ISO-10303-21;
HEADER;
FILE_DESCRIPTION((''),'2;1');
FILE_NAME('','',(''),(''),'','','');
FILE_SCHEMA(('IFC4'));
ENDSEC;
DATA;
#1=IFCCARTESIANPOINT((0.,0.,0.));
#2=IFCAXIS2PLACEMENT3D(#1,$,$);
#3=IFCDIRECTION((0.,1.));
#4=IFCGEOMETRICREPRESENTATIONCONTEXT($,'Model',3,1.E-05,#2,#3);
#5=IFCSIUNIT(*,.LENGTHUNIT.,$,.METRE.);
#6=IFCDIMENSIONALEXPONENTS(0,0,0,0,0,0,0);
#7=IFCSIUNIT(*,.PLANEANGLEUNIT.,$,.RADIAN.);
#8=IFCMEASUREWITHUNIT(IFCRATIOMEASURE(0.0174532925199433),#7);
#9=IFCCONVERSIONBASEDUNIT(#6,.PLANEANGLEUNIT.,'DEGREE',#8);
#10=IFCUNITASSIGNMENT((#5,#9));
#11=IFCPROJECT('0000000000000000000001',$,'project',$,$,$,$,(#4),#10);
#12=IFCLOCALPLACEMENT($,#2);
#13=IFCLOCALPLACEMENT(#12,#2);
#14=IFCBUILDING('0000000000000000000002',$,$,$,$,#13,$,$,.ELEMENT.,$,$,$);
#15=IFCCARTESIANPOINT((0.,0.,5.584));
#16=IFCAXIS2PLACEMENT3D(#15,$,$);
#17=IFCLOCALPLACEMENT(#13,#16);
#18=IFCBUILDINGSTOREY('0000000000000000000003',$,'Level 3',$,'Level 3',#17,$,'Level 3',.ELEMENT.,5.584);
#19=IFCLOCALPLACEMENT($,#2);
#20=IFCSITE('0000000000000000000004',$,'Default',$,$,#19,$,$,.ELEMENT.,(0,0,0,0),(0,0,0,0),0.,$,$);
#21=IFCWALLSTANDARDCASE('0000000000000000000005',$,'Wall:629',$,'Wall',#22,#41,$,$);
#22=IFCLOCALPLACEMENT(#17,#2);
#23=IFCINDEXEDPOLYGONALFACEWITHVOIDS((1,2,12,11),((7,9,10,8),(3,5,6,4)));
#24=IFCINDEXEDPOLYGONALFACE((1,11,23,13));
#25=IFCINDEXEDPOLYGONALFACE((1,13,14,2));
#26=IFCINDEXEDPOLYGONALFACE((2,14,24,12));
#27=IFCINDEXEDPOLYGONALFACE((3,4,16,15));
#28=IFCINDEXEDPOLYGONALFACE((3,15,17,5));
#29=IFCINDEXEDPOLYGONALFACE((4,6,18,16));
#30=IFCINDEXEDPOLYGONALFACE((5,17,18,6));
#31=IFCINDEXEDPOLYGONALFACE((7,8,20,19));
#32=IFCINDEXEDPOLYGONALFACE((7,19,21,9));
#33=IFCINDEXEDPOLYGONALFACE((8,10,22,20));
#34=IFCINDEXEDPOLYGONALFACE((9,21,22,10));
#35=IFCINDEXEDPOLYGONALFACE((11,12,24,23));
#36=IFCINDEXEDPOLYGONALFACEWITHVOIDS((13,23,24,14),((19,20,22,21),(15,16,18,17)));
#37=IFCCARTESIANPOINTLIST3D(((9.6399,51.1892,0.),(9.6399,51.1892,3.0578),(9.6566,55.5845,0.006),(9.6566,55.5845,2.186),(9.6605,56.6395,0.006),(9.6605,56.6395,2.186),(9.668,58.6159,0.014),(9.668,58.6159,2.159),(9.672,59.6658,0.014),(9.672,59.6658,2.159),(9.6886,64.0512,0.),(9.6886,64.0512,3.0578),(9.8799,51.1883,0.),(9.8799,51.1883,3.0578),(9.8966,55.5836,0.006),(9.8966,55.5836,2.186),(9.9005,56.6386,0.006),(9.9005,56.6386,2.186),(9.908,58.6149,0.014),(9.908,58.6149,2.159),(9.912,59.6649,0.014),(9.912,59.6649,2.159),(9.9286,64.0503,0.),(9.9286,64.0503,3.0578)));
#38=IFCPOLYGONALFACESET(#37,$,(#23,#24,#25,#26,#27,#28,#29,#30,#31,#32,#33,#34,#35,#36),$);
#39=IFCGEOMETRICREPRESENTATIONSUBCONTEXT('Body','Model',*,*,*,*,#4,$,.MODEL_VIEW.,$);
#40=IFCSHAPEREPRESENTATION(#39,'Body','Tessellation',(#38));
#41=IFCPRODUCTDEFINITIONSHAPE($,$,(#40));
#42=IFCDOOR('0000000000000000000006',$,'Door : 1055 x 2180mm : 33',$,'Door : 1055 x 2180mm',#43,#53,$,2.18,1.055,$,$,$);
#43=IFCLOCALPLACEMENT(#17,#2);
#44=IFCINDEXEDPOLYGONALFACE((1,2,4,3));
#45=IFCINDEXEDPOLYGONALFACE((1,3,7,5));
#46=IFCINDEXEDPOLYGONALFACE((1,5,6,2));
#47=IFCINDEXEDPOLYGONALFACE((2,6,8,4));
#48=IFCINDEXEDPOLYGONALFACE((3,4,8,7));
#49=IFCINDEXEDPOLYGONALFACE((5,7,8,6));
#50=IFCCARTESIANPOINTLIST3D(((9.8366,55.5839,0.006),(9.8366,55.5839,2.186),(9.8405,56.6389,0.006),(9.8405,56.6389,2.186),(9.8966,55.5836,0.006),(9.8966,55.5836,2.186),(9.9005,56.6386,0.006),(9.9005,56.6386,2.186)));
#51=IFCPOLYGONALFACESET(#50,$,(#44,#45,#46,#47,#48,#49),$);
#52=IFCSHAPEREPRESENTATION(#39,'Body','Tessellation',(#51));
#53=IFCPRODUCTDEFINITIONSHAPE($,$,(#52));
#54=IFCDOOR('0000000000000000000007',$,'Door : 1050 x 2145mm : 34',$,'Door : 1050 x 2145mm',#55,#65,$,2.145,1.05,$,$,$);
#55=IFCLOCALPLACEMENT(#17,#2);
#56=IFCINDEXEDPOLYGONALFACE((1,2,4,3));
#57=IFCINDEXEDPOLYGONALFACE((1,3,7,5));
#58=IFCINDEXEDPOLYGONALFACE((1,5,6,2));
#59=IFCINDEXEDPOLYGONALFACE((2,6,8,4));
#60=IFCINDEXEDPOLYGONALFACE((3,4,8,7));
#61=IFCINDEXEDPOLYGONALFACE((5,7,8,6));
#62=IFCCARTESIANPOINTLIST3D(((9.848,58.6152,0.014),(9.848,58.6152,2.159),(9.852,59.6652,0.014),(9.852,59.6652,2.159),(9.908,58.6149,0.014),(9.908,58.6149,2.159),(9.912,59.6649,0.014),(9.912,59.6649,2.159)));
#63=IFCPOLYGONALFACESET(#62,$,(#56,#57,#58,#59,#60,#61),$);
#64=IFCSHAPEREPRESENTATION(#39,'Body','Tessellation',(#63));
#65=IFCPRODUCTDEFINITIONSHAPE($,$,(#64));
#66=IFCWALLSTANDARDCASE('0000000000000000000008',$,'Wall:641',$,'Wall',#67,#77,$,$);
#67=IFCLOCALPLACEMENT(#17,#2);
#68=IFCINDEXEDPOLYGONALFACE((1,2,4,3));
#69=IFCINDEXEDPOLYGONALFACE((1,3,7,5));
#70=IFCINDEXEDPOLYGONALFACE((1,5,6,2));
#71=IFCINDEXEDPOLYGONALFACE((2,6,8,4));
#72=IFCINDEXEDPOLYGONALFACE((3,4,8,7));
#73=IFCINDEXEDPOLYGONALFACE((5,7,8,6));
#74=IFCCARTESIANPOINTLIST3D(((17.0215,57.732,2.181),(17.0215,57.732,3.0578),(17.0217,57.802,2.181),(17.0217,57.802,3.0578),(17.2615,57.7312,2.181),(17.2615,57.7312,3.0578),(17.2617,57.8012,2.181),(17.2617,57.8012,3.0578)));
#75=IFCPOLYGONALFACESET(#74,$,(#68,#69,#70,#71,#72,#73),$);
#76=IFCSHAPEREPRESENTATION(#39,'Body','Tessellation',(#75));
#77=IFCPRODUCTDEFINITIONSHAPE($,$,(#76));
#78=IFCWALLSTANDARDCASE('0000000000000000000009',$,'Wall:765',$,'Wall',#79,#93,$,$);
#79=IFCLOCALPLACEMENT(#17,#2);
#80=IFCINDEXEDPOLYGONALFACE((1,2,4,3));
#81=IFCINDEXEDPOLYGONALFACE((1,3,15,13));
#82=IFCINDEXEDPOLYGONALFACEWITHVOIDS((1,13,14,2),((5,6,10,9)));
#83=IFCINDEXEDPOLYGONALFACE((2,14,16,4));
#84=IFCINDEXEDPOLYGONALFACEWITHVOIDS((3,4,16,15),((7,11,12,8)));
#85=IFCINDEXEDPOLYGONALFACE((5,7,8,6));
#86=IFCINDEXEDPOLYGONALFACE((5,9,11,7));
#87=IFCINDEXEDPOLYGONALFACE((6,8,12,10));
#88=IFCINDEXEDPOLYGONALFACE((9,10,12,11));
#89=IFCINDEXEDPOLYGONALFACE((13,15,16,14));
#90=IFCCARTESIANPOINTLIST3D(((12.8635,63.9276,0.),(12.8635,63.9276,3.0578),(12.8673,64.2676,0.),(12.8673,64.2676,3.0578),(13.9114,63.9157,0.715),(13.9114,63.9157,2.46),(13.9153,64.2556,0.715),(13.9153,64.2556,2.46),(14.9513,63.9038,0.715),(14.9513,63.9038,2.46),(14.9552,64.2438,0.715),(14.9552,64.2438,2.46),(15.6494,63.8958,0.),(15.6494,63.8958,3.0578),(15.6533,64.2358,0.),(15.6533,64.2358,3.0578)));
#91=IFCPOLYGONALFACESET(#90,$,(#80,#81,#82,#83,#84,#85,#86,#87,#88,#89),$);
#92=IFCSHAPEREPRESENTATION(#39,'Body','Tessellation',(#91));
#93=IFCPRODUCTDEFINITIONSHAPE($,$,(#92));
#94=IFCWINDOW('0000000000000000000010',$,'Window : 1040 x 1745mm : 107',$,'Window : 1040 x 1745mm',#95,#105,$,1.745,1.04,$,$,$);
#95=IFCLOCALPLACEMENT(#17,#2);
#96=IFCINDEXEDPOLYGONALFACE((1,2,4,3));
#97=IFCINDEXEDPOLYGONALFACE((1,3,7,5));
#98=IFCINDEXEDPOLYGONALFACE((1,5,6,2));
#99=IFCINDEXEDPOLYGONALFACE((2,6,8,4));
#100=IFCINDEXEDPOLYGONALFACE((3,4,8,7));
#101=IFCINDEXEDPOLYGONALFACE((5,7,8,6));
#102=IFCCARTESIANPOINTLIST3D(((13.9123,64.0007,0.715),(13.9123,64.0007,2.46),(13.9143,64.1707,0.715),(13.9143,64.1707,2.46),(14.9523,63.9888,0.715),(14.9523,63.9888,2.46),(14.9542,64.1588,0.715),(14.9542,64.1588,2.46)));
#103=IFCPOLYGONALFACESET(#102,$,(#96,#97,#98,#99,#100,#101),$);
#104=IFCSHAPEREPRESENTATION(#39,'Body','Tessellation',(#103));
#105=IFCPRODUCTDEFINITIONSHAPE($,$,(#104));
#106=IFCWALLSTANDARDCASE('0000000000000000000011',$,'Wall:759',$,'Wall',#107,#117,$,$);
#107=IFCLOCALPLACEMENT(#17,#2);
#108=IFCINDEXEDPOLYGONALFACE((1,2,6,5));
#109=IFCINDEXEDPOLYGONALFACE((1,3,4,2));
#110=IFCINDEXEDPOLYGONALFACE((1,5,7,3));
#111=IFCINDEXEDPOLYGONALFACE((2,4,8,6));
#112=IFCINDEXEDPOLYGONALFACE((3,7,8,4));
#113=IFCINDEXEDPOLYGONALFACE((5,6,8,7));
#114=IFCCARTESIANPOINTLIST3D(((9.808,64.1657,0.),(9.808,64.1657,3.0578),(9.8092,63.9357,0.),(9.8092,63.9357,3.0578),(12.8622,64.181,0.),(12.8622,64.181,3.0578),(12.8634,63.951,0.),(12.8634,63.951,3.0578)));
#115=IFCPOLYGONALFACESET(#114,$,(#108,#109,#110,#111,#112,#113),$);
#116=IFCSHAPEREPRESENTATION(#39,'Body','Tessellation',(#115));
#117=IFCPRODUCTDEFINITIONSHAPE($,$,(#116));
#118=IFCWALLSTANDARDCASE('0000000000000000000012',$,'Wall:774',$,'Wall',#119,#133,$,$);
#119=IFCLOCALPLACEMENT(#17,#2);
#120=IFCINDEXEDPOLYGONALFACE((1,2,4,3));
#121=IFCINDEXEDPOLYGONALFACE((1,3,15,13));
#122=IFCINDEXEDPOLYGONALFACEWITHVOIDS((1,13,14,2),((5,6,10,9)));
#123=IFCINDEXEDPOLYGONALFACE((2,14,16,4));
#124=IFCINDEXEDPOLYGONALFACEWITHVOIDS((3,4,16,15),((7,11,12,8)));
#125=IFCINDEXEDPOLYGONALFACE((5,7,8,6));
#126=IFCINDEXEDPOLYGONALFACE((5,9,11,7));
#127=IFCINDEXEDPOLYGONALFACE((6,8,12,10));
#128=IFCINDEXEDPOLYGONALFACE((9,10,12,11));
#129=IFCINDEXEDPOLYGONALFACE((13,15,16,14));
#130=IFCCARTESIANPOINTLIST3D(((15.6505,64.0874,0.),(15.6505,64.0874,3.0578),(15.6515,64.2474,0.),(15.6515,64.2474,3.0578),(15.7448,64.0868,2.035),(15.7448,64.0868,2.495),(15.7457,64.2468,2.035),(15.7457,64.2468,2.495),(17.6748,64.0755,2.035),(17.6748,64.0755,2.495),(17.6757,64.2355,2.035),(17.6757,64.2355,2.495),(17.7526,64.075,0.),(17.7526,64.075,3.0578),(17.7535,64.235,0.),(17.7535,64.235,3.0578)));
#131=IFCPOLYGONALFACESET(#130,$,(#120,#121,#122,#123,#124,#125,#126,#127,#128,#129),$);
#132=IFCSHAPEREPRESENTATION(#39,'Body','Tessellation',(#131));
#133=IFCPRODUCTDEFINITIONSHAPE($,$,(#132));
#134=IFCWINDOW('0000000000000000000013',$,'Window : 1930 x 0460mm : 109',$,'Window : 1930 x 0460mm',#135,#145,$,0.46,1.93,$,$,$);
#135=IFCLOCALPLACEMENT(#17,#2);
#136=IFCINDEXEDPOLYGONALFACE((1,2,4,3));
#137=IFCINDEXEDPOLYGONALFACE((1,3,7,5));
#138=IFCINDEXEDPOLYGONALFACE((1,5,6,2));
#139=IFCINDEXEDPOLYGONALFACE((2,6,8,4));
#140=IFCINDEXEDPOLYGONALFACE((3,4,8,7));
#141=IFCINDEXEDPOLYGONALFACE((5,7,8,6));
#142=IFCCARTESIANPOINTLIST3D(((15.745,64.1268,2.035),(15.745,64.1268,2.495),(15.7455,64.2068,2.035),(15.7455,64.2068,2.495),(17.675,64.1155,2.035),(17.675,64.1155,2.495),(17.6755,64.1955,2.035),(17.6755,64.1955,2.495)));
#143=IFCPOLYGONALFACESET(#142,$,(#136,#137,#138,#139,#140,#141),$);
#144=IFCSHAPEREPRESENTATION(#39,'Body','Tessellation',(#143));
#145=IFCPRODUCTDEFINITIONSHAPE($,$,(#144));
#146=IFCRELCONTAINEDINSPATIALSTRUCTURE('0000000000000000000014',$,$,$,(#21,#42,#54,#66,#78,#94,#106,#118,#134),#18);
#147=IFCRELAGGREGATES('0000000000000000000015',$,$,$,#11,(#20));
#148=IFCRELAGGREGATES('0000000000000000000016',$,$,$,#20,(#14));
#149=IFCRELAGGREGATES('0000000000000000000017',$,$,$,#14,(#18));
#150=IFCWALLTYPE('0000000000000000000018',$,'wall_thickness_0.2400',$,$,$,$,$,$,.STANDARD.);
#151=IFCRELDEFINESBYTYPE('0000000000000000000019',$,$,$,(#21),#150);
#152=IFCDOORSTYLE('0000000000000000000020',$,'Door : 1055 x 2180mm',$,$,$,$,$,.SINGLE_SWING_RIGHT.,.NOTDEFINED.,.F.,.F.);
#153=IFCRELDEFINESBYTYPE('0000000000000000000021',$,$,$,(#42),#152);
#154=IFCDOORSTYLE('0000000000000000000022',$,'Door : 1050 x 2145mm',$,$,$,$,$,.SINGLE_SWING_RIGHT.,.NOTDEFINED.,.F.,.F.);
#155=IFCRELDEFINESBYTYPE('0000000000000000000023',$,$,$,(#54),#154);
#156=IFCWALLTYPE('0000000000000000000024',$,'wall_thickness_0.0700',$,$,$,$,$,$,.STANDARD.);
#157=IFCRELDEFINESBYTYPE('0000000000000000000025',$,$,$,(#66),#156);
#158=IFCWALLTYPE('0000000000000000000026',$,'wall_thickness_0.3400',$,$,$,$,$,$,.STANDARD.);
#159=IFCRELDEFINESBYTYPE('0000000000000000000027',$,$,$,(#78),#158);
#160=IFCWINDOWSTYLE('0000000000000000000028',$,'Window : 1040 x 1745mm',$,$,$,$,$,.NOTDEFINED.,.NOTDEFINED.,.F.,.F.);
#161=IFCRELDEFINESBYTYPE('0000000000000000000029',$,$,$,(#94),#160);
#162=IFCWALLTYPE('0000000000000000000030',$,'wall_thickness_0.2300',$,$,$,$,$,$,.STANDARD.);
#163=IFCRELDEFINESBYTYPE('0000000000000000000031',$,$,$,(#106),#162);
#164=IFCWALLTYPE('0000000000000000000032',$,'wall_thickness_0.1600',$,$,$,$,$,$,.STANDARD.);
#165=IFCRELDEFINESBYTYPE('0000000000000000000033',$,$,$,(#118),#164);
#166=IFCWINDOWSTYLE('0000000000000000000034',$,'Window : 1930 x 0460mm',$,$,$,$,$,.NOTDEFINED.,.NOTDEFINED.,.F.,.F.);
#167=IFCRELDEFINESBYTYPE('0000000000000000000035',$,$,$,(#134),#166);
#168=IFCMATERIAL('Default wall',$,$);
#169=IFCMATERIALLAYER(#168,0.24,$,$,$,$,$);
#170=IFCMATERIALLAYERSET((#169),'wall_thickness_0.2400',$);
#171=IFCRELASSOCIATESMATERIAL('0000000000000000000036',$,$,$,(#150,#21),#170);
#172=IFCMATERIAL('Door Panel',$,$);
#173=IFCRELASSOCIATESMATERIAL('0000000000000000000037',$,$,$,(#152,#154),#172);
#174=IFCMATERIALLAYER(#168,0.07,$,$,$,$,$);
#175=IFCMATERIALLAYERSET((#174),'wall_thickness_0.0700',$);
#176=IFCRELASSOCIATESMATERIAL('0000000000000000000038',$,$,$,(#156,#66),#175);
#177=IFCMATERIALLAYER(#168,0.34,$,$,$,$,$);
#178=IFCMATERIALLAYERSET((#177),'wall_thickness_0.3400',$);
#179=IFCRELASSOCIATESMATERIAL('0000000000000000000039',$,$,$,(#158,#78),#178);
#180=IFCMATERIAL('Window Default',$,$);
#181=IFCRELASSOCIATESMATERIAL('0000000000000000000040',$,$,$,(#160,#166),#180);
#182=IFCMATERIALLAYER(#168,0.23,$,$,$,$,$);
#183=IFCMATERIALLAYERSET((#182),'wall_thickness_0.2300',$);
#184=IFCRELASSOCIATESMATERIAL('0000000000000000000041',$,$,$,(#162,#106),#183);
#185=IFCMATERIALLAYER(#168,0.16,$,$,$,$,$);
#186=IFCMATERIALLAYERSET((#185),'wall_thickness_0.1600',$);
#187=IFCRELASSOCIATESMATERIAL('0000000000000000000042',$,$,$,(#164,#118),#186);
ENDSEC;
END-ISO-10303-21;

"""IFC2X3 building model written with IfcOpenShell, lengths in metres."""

from ifc_helpers import new_model, entity, si_unit, converted_unit, direction, frame, frame_2d, origin, origin_2d_with_axis, place, context, subcontext, project, spatial, polyline, rectangle, outline, extrude, source, transform, mapped, material, layer, layer_set, layer_usage, type_object, type_shapes, element, fill, save


model = new_model("IFC2X3")

# Units and contexts
model_context = context("Model", 3, precision=1e-05, world=origin(), true_north=direction((0.0, 1.0)))
body_context = subcontext(model_context, "Body", "Model", "MODEL_VIEW")
ifc_project = project(units=[si_unit("LENGTHUNIT", "METRE"), converted_unit("PLANEANGLEUNIT", "DEGREE", entity("IfcRatioMeasure", 0.0174532925199433), si_unit("PLANEANGLEUNIT", "RADIAN"), dimensions=[0, 0, 0, 0, 0, 0, 0])], contexts=[model_context])

# Site, building, storey
site_placement = place(None, origin())
site = spatial("IfcSite", under=ifc_project, at=site_placement, Name="Default", CompositionType="ELEMENT", RefLatitude=(0, 0, 0, 0), RefLongitude=(0, 0, 0, 0), RefElevation=0.0)
placement_1 = place(None, origin())
building_placement = place(placement_1, origin())
building = spatial("IfcBuilding", under=site, at=building_placement, CompositionType="ELEMENT")
storey_placement = place(building_placement, frame((0.0, 0.0, 5.584)))
storey = spatial("IfcBuildingStorey", under=building, at=storey_placement, Name="Level 3", ObjectType="Level 3", LongName="Level 3", CompositionType="ELEMENT", Elevation=5.584)

# Shared definitions
ifc_material_1 = material(Name="Default wall")

# Shared definitions
ifc_material_2 = material(Name="Window Default")

# Wall, openings, doors
ifc_layer_1 = layer(ifc_material_1, 0.24)
ifc_layer_set_1 = layer_set([ifc_layer_1], Name="wall_thickness_0.2400")
ifc_layer_usage_1 = layer_usage(ifc_layer_set_1, "AXIS2", "POSITIVE", -0.12)
wall_type_1 = type_object("IfcWallType", Name="wall_thickness_0.2400", PredefinedType="STANDARD", material=ifc_layer_set_1)
wall_1_placement = place(storey_placement, frame((9.8086, 64.0507, 0.0), z_axis=(0.0, 0.0, 1.0), x_axis=(-0.003783, -0.999993, 0.0)))
wall_1 = element("IfcWallStandardCase", 1, at=wall_1_placement, inside=storey, type_object=wall_type_1, material=ifc_layer_usage_1, Name="Wall:629", ObjectType="Wall", context=body_context, shape_type="SweptSolid", body=[
    extrude(outline(polyline([(12.8621, -0.12), (12.8621, 0.12), (0.0, 0.12), (0.0, -0.12), (12.8621, -0.12)])), origin(), (0.0, 0.0, 1.0), 3.0578),
])
opening_1_placement = place(wall_1_placement, frame((7.4117, -0.12, 0.006)))
opening_1 = element("IfcOpeningElement", 2, at=opening_1_placement, cuts=wall_1, ObjectType="Opening", context=body_context, shape_type="SweptSolid", body=[
    extrude(rectangle(XDim=1.055, YDim=2.18, at=frame_2d((1.09, 0.5275), x_axis=(0.0, 1.0))), frame((0.0, 0.0, 0.0), z_axis=(0.0, 1.0, 0.0), x_axis=(0.0, 0.0, 1.0)), (0.0, 0.0, 1.0), 0.24),
])
opening_2_placement = place(wall_1_placement, frame((4.3854, -0.12, 0.014)))
opening_2 = element("IfcOpeningElement", 3, at=opening_2_placement, cuts=wall_1, ObjectType="Opening", context=body_context, shape_type="SweptSolid", body=[
    extrude(rectangle(XDim=1.05, YDim=2.145, at=frame_2d((1.0725, 0.525), x_axis=(0.0, 1.0))), frame((0.0, 0.0, 0.0), z_axis=(0.0, 1.0, 0.0), x_axis=(0.0, 0.0, 1.0)), (0.0, 0.0, 1.0), 0.24),
])
ifc_material_3 = material(Name="Door Panel")
door_style_1 = type_object("IfcDoorStyle", Name="Door : 1055 x 2180mm", ConstructionType="NOTDEFINED", OperationType="SINGLE_SWING_RIGHT", ParameterTakesPrecedence=False, Sizeable=False, material=ifc_material_3)
shared_shape_1 = source(origin(), body_context, "Body", "SweptSolid", [
    extrude(rectangle(XDim=0.06, YDim=1.055, at=origin_2d_with_axis()), frame((0.5275, 0.21, 0.0), z_axis=(0.0, 0.0, 1.0), x_axis=(0.0, 1.0, 0.0)), (0.0, 0.0, 1.0), 2.18),
])
type_shapes(door_style_1, [shared_shape_1])
door_1_placement = place(opening_1_placement, origin())
door_1 = element("IfcDoor", 4, at=door_1_placement, inside=storey, type_object=door_style_1, Name="Door : 1055 x 2180mm : 33", ObjectType="Door : 1055 x 2180mm", OverallHeight=2.18, OverallWidth=1.055, context=body_context, shape_type="MappedRepresentation", body=[
    mapped(shared_shape_1, transform((0.0, 0.0, 0.0), scale=1.0)),
])
fill(opening_1, door_1)
door_style_2 = type_object("IfcDoorStyle", Name="Door : 1050 x 2145mm", ConstructionType="NOTDEFINED", OperationType="SINGLE_SWING_RIGHT", ParameterTakesPrecedence=False, Sizeable=False, material=ifc_material_3)
shared_shape_2 = source(origin(), body_context, "Body", "SweptSolid", [
    extrude(rectangle(XDim=0.06, YDim=1.05, at=origin_2d_with_axis()), frame((0.525, 0.21, 0.0), z_axis=(0.0, 0.0, 1.0), x_axis=(0.0, 1.0, 0.0)), (0.0, 0.0, 1.0), 2.145),
])
type_shapes(door_style_2, [shared_shape_2])
door_2_placement = place(opening_2_placement, origin())
door_2 = element("IfcDoor", 5, at=door_2_placement, inside=storey, type_object=door_style_2, Name="Door : 1050 x 2145mm : 34", ObjectType="Door : 1050 x 2145mm", OverallHeight=2.145, OverallWidth=1.05, context=body_context, shape_type="MappedRepresentation", body=[
    mapped(shared_shape_2, transform((0.0, 0.0, 0.0), scale=1.0)),
])
fill(opening_2, door_2)

# Wall
ifc_layer_2 = layer(ifc_material_1, 0.07)
ifc_layer_set_2 = layer_set([ifc_layer_2], Name="wall_thickness_0.0700")
ifc_layer_usage_2 = layer_usage(ifc_layer_set_2, "AXIS2", "POSITIVE", -0.035)
wall_type_2 = type_object("IfcWallType", Name="wall_thickness_0.0700", PredefinedType="STANDARD", material=ifc_layer_set_2)
placement_2 = place(building_placement, frame((0.0, 0.0, 7.765)))
wall_2_placement = place(placement_2, frame((17.0216, 57.767, 0.0), z_axis=(0.0, 0.0, 1.0), x_axis=(0.999995, -0.00302, 0.0)))
element("IfcWallStandardCase", 6, at=wall_2_placement, inside=storey, type_object=wall_type_2, material=ifc_layer_usage_2, Name="Wall:641", ObjectType="Wall", context=body_context, shape_type="SweptSolid", body=[
    extrude(outline(polyline([(0.24, -0.035), (0.24, 0.035), (0.0, 0.035), (0.0, -0.035), (0.24, -0.035)])), origin(), (0.0, 0.0, 1.0), 0.8768),
])

# Wall, opening, window
ifc_layer_3 = layer(ifc_material_1, 0.34)
ifc_layer_set_3 = layer_set([ifc_layer_3], Name="wall_thickness_0.3400")
ifc_layer_usage_3 = layer_usage(ifc_layer_set_3, "AXIS2", "POSITIVE", -0.17)
wall_type_3 = type_object("IfcWallType", Name="wall_thickness_0.3400", PredefinedType="STANDARD", material=ifc_layer_set_3)
wall_3_placement = place(storey_placement, frame((12.8654, 64.0976, 0.0), z_axis=(0.0, 0.0, 1.0), x_axis=(0.999935, -0.011416, 0.0)))
wall_3 = element("IfcWallStandardCase", 7, at=wall_3_placement, inside=storey, type_object=wall_type_3, material=ifc_layer_usage_3, Name="Wall:765", ObjectType="Wall", context=body_context, shape_type="SweptSolid", body=[
    extrude(outline(polyline([(2.7861, -0.17), (2.7861, 0.17), (0.0, 0.17), (0.0, -0.17), (2.7861, -0.17)])), origin(), (0.0, 0.0, 1.0), 3.0578),
])
opening_3_placement = place(wall_3_placement, frame((1.048, -0.17, 0.715)))
opening_3 = element("IfcOpeningElement", 8, at=opening_3_placement, cuts=wall_3, ObjectType="Opening", context=body_context, shape_type="SweptSolid", body=[
    extrude(rectangle(XDim=1.04, YDim=1.745, at=frame_2d((0.8725, 0.52), x_axis=(0.0, 1.0))), frame((0.0, 0.0, 0.0), z_axis=(0.0, 1.0, 0.0), x_axis=(0.0, 0.0, 1.0)), (0.0, 0.0, 1.0), 0.34),
])
window_style_1 = type_object("IfcWindowStyle", Name="Window : 1040 x 1745mm", ConstructionType="NOTDEFINED", OperationType="NOTDEFINED", ParameterTakesPrecedence=False, Sizeable=False, material=ifc_material_2)
shared_shape_3 = source(origin(), body_context, "Body", "SweptSolid", [
    extrude(rectangle(XDim=0.17, YDim=1.04, at=origin_2d_with_axis()), frame((0.52, 0.17, 0.0), z_axis=(0.0, 0.0, 1.0), x_axis=(0.0, 1.0, 0.0)), (0.0, 0.0, 1.0), 1.745),
])
type_shapes(window_style_1, [shared_shape_3])
window_1_placement = place(opening_3_placement, origin())
window_1 = element("IfcWindow", 9, at=window_1_placement, inside=storey, type_object=window_style_1, Name="Window : 1040 x 1745mm : 107", ObjectType="Window : 1040 x 1745mm", OverallHeight=1.745, OverallWidth=1.04, context=body_context, shape_type="MappedRepresentation", body=[
    mapped(shared_shape_3, transform((0.0, 0.0, 0.0), scale=1.0)),
])
fill(opening_3, window_1)

# Wall
ifc_layer_4 = layer(ifc_material_1, 0.23)
ifc_layer_set_4 = layer_set([ifc_layer_4], Name="wall_thickness_0.2300")
ifc_layer_usage_4 = layer_usage(ifc_layer_set_4, "AXIS2", "POSITIVE", -0.115)
wall_type_4 = type_object("IfcWallType", Name="wall_thickness_0.2300", PredefinedType="STANDARD", material=ifc_layer_set_4)
wall_4_placement = place(storey_placement, frame((9.8086, 64.0507, 0.0), z_axis=(0.0, 0.0, 1.0), x_axis=(0.999987, 0.005001, 0.0)))
element("IfcWallStandardCase", 10, at=wall_4_placement, inside=storey, type_object=wall_type_4, material=ifc_layer_usage_4, Name="Wall:759", ObjectType="Wall", context=body_context, shape_type="SweptSolid", body=[
    extrude(outline(polyline([(3.0542, -0.115), (3.0542, 0.115), (0.0, 0.115), (0.0, -0.115), (3.0542, -0.115)])), origin(), (0.0, 0.0, 1.0), 3.0578),
])

# Wall, opening, window
ifc_layer_5 = layer(ifc_material_1, 0.16)
ifc_layer_set_5 = layer_set([ifc_layer_5], Name="wall_thickness_0.1600")
ifc_layer_usage_5 = layer_usage(ifc_layer_set_5, "AXIS2", "POSITIVE", -0.08)
wall_type_5 = type_object("IfcWallType", Name="wall_thickness_0.1600", PredefinedType="STANDARD", material=ifc_layer_set_5)
wall_5_placement = place(storey_placement, frame((15.651, 64.1674, 0.0), z_axis=(0.0, 0.0, 1.0), x_axis=(0.999983, -0.005876, 0.0)))
wall_5 = element("IfcWallStandardCase", 11, at=wall_5_placement, inside=storey, type_object=wall_type_5, material=ifc_layer_usage_5, Name="Wall:774", ObjectType="Wall", context=body_context, shape_type="SweptSolid", body=[
    extrude(outline(polyline([(2.1021, -0.08), (2.1021, 0.08), (0.0, 0.08), (0.0, -0.08), (2.1021, -0.08)])), origin(), (0.0, 0.0, 1.0), 3.0578),
])
opening_4_placement = place(wall_5_placement, frame((0.0943, -0.08, 2.035)))
opening_4 = element("IfcOpeningElement", 12, at=opening_4_placement, cuts=wall_5, ObjectType="Opening", context=body_context, shape_type="SweptSolid", body=[
    extrude(rectangle(XDim=1.93, YDim=0.46, at=frame_2d((0.23, 0.965), x_axis=(0.0, 1.0))), frame((0.0, 0.0, 0.0), z_axis=(0.0, 1.0, 0.0), x_axis=(0.0, 0.0, 1.0)), (0.0, 0.0, 1.0), 0.16),
])
window_style_2 = type_object("IfcWindowStyle", Name="Window : 1930 x 0460mm", ConstructionType="NOTDEFINED", OperationType="NOTDEFINED", ParameterTakesPrecedence=False, Sizeable=False, material=ifc_material_2)
shared_shape_4 = source(origin(), body_context, "Body", "SweptSolid", [
    extrude(rectangle(XDim=0.08, YDim=1.93, at=origin_2d_with_axis()), frame((0.965, 0.08, 0.0), z_axis=(0.0, 0.0, 1.0), x_axis=(0.0, 1.0, 0.0)), (0.0, 0.0, 1.0), 0.46),
])
type_shapes(window_style_2, [shared_shape_4])
window_2_placement = place(opening_4_placement, origin())
window_2 = element("IfcWindow", 13, at=window_2_placement, inside=storey, type_object=window_style_2, Name="Window : 1930 x 0460mm : 109", ObjectType="Window : 1930 x 0460mm", OverallHeight=0.46, OverallWidth=1.93, context=body_context, shape_type="MappedRepresentation", body=[
    mapped(shared_shape_4, transform((0.0, 0.0, 0.0), scale=1.0)),
])
fill(opening_4, window_2)

save(model, "model.ifc")
